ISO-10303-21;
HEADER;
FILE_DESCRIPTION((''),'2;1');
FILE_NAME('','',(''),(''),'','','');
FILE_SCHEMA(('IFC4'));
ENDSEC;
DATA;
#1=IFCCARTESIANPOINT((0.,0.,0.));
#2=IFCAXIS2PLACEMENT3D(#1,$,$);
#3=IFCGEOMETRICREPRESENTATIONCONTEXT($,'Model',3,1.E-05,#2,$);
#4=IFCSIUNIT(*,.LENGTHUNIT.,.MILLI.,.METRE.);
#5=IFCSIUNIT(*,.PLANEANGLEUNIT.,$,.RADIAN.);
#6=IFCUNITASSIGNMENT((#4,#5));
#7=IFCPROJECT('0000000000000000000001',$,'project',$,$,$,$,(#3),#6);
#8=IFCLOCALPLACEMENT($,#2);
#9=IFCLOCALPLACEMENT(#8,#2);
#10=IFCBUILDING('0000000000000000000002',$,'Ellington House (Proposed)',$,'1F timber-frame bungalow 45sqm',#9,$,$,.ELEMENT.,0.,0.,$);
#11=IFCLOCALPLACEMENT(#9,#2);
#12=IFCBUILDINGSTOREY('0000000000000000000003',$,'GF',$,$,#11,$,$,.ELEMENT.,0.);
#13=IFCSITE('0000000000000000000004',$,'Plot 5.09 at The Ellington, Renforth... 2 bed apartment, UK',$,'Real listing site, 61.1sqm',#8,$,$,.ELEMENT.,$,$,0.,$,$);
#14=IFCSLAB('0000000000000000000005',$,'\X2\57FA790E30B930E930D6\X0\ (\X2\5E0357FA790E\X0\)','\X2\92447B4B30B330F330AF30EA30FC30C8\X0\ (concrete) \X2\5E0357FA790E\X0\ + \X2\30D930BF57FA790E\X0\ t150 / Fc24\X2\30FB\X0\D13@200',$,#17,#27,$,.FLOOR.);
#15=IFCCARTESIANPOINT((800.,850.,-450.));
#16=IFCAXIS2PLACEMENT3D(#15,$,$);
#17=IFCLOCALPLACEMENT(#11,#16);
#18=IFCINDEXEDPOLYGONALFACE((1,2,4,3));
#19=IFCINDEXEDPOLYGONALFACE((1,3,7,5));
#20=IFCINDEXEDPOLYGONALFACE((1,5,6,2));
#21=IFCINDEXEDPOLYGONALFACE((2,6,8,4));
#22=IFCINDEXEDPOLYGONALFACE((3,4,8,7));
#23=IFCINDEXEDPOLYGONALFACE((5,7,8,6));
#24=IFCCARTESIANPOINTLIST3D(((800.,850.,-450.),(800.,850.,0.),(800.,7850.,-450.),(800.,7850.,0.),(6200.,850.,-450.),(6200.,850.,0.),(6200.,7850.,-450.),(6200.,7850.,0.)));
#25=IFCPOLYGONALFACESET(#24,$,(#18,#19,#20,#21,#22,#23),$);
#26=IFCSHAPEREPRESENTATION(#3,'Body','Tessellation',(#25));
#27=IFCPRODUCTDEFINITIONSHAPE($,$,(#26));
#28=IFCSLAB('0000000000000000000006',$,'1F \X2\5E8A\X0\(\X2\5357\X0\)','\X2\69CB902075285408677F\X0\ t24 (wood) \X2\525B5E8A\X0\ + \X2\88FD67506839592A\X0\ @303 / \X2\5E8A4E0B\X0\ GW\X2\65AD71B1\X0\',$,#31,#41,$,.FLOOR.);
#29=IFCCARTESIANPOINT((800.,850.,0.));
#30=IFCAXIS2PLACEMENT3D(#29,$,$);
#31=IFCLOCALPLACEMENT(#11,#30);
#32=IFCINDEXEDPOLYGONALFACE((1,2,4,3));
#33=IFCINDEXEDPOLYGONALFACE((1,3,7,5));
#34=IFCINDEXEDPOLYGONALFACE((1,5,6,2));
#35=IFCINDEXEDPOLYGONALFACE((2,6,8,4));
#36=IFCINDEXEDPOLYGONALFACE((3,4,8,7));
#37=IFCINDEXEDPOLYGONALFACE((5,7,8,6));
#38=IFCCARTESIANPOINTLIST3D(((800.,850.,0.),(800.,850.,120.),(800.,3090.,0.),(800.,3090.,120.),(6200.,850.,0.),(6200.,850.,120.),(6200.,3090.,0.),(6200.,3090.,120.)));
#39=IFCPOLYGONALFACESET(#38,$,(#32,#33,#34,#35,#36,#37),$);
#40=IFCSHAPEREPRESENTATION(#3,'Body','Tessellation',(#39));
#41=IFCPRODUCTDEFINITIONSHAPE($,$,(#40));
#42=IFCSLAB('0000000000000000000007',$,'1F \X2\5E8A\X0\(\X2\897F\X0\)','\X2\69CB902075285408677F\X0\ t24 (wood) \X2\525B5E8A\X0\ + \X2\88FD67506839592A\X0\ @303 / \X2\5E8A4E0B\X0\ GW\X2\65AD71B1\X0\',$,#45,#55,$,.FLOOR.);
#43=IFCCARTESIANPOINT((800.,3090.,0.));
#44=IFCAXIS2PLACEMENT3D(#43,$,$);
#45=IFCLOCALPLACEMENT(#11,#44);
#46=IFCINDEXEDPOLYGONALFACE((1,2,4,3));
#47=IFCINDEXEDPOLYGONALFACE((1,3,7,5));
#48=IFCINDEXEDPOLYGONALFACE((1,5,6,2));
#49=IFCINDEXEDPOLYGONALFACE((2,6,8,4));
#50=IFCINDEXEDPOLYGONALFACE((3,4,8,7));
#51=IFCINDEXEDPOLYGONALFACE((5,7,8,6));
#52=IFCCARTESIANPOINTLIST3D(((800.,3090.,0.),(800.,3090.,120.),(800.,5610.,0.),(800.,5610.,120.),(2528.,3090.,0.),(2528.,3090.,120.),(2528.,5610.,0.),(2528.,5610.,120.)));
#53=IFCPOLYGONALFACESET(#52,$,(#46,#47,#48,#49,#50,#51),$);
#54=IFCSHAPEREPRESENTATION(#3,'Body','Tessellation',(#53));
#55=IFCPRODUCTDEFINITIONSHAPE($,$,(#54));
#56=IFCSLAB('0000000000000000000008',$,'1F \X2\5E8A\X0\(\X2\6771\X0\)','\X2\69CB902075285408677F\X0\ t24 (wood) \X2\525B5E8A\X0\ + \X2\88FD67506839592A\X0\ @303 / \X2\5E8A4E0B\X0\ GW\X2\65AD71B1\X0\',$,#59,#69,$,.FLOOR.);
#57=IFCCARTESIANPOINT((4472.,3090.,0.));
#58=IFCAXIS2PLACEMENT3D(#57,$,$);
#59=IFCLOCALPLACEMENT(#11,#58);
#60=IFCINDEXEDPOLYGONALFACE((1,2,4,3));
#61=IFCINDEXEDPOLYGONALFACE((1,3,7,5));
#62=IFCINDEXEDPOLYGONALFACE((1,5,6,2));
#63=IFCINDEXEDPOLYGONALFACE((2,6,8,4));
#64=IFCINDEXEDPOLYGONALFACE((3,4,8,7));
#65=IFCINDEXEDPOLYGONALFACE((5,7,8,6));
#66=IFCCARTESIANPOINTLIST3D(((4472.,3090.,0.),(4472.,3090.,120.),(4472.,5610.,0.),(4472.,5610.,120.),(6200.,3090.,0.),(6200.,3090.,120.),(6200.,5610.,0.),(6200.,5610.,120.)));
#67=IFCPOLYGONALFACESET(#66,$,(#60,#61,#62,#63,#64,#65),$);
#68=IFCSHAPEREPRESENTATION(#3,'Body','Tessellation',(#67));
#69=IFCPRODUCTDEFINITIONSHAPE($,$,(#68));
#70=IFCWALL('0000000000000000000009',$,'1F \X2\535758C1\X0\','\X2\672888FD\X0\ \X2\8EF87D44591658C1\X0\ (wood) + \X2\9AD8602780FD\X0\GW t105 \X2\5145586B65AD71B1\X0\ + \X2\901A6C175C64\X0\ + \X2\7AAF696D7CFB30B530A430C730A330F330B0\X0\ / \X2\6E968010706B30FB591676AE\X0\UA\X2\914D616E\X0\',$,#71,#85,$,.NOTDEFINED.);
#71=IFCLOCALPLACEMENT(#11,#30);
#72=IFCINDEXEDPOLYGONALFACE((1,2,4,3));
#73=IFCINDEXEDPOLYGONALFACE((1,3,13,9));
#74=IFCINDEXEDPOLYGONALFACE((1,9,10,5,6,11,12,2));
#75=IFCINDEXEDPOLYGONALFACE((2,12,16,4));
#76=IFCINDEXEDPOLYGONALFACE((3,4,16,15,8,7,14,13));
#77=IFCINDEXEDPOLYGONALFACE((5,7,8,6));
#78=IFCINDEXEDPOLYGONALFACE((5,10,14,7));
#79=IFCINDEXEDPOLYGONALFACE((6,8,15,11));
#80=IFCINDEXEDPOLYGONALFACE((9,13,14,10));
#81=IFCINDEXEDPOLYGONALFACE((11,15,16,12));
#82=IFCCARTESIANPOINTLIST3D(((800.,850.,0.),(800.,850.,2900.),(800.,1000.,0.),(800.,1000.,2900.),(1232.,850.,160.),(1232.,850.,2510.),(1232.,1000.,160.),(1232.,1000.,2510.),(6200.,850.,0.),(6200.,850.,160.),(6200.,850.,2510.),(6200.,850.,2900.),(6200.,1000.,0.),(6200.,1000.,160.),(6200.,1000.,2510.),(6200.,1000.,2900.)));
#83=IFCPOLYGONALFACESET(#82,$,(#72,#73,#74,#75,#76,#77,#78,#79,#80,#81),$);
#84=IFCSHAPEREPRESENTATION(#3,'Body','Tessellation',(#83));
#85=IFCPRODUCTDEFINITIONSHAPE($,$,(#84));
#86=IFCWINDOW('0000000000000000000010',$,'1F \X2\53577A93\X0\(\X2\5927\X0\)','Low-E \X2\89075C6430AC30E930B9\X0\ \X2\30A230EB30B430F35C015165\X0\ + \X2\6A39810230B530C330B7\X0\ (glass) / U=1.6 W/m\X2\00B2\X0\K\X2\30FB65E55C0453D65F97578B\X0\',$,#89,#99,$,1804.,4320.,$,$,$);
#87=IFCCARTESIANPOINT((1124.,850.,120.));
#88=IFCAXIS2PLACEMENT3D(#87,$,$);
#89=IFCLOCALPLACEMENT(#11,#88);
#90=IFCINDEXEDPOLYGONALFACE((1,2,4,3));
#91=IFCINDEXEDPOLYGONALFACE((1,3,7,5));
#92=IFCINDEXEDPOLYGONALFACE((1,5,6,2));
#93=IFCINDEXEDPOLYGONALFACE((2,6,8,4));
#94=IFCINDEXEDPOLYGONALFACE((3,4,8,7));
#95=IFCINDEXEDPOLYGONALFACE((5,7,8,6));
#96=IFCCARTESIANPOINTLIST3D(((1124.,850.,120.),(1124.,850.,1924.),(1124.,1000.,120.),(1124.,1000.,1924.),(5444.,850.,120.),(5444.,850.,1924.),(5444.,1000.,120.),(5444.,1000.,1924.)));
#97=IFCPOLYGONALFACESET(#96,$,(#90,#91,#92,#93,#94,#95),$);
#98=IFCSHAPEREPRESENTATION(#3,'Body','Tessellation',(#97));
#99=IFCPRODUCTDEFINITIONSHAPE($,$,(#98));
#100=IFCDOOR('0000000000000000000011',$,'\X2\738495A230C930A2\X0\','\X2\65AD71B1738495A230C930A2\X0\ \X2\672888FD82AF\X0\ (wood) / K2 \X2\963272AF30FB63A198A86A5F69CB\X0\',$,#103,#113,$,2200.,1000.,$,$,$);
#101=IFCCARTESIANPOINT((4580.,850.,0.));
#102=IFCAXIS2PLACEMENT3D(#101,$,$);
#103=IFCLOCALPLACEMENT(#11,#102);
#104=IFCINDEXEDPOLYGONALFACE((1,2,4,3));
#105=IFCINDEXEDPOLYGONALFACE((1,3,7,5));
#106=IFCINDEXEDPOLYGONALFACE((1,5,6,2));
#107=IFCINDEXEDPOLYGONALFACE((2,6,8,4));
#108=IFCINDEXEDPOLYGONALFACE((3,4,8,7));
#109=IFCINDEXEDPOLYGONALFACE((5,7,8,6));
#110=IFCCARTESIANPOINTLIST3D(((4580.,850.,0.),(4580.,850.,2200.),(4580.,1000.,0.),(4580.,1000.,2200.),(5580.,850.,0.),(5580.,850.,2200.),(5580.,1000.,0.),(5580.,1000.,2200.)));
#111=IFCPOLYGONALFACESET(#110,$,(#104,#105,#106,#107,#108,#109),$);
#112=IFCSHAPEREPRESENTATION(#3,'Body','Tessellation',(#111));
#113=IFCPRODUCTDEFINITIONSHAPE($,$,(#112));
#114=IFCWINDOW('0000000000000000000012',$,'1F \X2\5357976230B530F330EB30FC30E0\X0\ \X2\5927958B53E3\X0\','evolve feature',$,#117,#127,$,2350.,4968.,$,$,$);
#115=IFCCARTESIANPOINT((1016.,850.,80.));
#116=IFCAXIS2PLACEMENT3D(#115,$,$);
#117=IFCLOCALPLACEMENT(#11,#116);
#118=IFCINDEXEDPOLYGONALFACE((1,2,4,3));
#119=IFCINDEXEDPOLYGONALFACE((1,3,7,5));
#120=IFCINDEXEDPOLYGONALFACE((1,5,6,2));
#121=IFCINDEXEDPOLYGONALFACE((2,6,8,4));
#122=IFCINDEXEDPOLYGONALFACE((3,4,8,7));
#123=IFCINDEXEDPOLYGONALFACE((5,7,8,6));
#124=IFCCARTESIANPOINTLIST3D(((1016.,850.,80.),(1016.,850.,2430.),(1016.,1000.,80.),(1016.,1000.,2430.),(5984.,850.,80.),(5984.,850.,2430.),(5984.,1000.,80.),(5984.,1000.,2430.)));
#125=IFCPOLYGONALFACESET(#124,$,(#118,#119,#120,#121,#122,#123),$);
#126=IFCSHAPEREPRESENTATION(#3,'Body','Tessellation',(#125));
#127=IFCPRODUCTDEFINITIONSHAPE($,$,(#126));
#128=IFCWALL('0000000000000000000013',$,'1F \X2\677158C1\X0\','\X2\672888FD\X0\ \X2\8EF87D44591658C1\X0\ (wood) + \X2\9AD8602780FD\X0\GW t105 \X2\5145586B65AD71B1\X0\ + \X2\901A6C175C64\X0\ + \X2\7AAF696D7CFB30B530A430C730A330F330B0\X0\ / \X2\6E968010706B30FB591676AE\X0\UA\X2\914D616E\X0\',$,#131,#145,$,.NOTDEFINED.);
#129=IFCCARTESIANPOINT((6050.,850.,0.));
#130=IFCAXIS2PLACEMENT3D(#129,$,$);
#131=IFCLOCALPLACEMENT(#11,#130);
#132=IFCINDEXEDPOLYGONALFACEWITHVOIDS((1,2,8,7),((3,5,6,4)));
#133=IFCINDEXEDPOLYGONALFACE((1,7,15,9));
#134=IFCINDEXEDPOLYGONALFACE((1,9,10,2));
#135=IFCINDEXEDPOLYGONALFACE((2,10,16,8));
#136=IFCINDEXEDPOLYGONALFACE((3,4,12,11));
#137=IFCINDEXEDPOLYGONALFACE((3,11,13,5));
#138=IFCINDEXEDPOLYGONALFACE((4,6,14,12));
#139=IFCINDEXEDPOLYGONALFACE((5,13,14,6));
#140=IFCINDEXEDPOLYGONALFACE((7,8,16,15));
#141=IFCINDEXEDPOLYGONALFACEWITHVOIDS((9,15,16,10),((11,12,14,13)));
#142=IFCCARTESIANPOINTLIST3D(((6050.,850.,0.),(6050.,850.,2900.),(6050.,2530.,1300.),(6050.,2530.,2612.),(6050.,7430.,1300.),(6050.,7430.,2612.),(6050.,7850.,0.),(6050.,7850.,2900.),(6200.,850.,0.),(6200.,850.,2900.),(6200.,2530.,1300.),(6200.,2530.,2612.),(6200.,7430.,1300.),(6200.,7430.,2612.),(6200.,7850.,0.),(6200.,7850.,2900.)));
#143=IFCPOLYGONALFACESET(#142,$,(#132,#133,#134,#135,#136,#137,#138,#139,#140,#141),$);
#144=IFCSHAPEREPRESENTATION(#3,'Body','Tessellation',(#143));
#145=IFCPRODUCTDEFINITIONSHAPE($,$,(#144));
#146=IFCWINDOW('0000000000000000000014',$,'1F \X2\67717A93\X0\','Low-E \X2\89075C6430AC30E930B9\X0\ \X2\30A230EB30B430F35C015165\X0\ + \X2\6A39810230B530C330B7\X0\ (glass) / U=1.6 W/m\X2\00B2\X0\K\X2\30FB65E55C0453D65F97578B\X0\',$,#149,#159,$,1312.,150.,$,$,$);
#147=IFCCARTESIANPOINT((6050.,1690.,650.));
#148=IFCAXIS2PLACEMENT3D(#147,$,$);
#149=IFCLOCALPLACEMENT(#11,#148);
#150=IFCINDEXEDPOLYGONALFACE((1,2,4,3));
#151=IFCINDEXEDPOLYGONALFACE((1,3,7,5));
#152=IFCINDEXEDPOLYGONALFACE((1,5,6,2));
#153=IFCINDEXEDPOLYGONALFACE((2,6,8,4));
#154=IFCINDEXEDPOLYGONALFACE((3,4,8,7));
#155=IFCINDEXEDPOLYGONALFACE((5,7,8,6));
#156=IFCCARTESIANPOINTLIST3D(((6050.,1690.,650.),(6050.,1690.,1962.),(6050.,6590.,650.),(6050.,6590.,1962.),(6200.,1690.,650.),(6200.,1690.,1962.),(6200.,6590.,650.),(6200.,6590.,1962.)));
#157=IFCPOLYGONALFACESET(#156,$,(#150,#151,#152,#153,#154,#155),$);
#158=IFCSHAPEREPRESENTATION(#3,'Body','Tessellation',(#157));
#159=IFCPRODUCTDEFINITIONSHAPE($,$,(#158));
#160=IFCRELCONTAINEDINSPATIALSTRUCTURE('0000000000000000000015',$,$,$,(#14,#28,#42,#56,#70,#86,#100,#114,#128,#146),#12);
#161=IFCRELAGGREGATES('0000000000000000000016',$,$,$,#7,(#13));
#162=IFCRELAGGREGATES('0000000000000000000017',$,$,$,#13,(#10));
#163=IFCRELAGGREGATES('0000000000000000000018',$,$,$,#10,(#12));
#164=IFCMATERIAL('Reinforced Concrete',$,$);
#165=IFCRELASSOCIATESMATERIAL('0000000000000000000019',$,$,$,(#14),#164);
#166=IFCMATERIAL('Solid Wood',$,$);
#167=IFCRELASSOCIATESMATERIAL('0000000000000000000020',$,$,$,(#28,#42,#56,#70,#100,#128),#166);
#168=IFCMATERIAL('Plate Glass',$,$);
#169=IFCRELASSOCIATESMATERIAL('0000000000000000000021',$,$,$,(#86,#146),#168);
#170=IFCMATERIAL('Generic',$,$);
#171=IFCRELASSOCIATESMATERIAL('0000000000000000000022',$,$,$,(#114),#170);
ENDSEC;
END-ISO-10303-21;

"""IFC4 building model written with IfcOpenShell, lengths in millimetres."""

from ifc_helpers import new_model, si_unit, frame, frame_2d, origin, place, context, project, spatial, rectangle, extrude, material, element, fill, save


model = new_model("IFC4")

# Units and contexts
model_context = context("Model", 3, precision=1e-05, world=origin())
ifc_project = project(units=[si_unit("LENGTHUNIT", "METRE", prefix="MILLI"), si_unit("PLANEANGLEUNIT", "RADIAN")], contexts=[model_context])

# Site, building, storey
site_placement = place(None, origin())
site = spatial("IfcSite", under=ifc_project, at=site_placement, Name="Plot 5.09 at The Ellington, Renforth... 2 bed apartment, UK", ObjectType="Real listing site, 61.1sqm", CompositionType="ELEMENT", RefElevation=0.0)
building_placement = place(site_placement, origin())
building = spatial("IfcBuilding", under=site, at=building_placement, Name="Ellington House (Proposed)", ObjectType="1F timber-frame bungalow 45sqm", CompositionType="ELEMENT", ElevationOfRefHeight=0.0, ElevationOfTerrain=0.0)
storey_placement = place(building_placement, origin())
storey = spatial("IfcBuildingStorey", under=building, at=storey_placement, Name="GF", CompositionType="ELEMENT", Elevation=0.0)

# Slabs
ifc_material_1 = material(Name="Reinforced Concrete")
slab_1_placement = place(storey_placement, frame((800.0, 850.0, -450.0)))
element("IfcSlab", 1, at=slab_1_placement, inside=storey, material=ifc_material_1, Name="基礎スラブ (布基礎)", Description="鉄筋コンクリート (concrete) 布基礎 + ベタ基礎 t150 / Fc24・D13@200", PredefinedType="FLOOR", context=model_context, shape_type="SweptSolid", body=[
    extrude(rectangle(XDim=5400.0, YDim=7000.0, at=frame_2d((2700.0, 3500.0))), frame((800.0, 850.0, -450.0)), (0.0, 0.0, 1.0), 450.0),
])
ifc_material_2 = material(Name="Solid Wood")
slab_2_placement = place(storey_placement, frame((800.0, 850.0, 0.0)))
element("IfcSlab", 2, at=slab_2_placement, inside=storey, material=ifc_material_2, Name="1F 床(南)", Description="構造用合板 t24 (wood) 剛床 + 製材根太 @303 / 床下 GW断熱", PredefinedType="FLOOR", context=model_context, shape_type="SweptSolid", body=[
    extrude(rectangle(XDim=5400.0, YDim=2240.0, at=frame_2d((2700.0, 1120.0))), frame((800.0, 850.0, 0.0)), (0.0, 0.0, 1.0), 120.0),
])
slab_3_placement = place(storey_placement, frame((800.0, 3090.0, 0.0)))
element("IfcSlab", 3, at=slab_3_placement, inside=storey, material=ifc_material_2, Name="1F 床(西)", Description="構造用合板 t24 (wood) 剛床 + 製材根太 @303 / 床下 GW断熱", PredefinedType="FLOOR", context=model_context, shape_type="SweptSolid", body=[
    extrude(rectangle(XDim=1728.0, YDim=2520.0, at=frame_2d((864.0, 1260.0))), frame((800.0, 3090.0, 0.0)), (0.0, 0.0, 1.0), 120.0),
])
slab_4_placement = place(storey_placement, frame((4472.0, 3090.0, 0.0)))
element("IfcSlab", 4, at=slab_4_placement, inside=storey, material=ifc_material_2, Name="1F 床(東)", Description="構造用合板 t24 (wood) 剛床 + 製材根太 @303 / 床下 GW断熱", PredefinedType="FLOOR", context=model_context, shape_type="SweptSolid", body=[
    extrude(rectangle(XDim=1728.0, YDim=2520.0, at=frame_2d((864.0, 1260.0))), frame((4472.0, 3090.0, 0.0)), (0.0, 0.0, 1.0), 120.0),
])

# Wall, openings, windows, door
wall_1_placement = place(storey_placement, frame((800.0, 850.0, 0.0)))
wall_1 = element("IfcWall", 5, at=wall_1_placement, inside=storey, material=ifc_material_2, Name="1F 南壁", Description="木製 軸組外壁 (wood) + 高性能GW t105 充填断熱 + 通気層 + 窯業系サイディング / 準耐火・外皮UA配慮", PredefinedType="NOTDEFINED", context=model_context, shape_type="SweptSolid", body=[
    extrude(rectangle(XDim=5400.0, YDim=150.0, at=frame_2d((2700.0, 75.0))), frame((800.0, 850.0, 0.0)), (0.0, 0.0, 1.0), 2900.0),
])
opening_1_placement = place(storey_placement, frame((1124.0, 850.0, 120.0)))
opening_1 = element("IfcOpeningElement", 6, at=opening_1_placement, cuts=wall_1, PredefinedType="NOTDEFINED", context=model_context, shape_type="SweptSolid", body=[
    extrude(rectangle(XDim=4320.0, YDim=150.0, at=frame_2d((2160.0, 75.0))), frame((1124.0, 850.0, 120.0)), (0.0, 0.0, 1.0), 1804.0),
])
opening_2_placement = place(storey_placement, frame((4580.0, 850.0, 0.0)))
opening_2 = element("IfcOpeningElement", 7, at=opening_2_placement, cuts=wall_1, PredefinedType="NOTDEFINED", context=model_context, shape_type="SweptSolid", body=[
    extrude(rectangle(XDim=1000.0, YDim=150.0, at=frame_2d((500.0, 75.0))), frame((4580.0, 850.0, 0.0)), (0.0, 0.0, 1.0), 2200.0),
])
opening_3_placement = place(storey_placement, frame((1016.0, 850.0, 80.0)))
opening_3 = element("IfcOpeningElement", 8, at=opening_3_placement, cuts=wall_1, PredefinedType="NOTDEFINED", context=model_context, shape_type="SweptSolid", body=[
    extrude(rectangle(XDim=4968.0, YDim=150.0, at=frame_2d((2484.0, 75.0))), frame((1016.0, 850.0, 80.0)), (0.0, 0.0, 1.0), 2350.0),
])
ifc_material_3 = material(Name="Plate Glass")
window_1_placement = place(storey_placement, frame((1124.0, 850.0, 120.0)))
window_1 = element("IfcWindow", 9, at=window_1_placement, inside=storey, material=ifc_material_3, Name="1F 南窓(大)", Description="Low-E 複層ガラス アルゴン封入 + 樹脂サッシ (glass) / U=1.6 W/m²K・日射取得型", OverallHeight=1804.0, OverallWidth=4320.0, context=model_context, shape_type="SweptSolid", body=[
    extrude(rectangle(XDim=4320.0, YDim=150.0, at=frame_2d((2160.0, 75.0))), frame((1124.0, 850.0, 120.0)), (0.0, 0.0, 1.0), 1804.0),
])
fill(opening_1, window_1)
door_placement = place(storey_placement, frame((4580.0, 850.0, 0.0)))
door = element("IfcDoor", 10, at=door_placement, inside=storey, material=ifc_material_2, Name="玄関ドア", Description="断熱玄関ドア 木製芯 (wood) / K2 防犯・採風機構", OverallHeight=2200.0, OverallWidth=1000.0, context=model_context, shape_type="SweptSolid", body=[
    extrude(rectangle(XDim=1000.0, YDim=150.0, at=frame_2d((500.0, 75.0))), frame((4580.0, 850.0, 0.0)), (0.0, 0.0, 1.0), 2200.0),
])
fill(opening_2, door)
ifc_material_4 = material(Name="Generic")
window_2_placement = place(storey_placement, frame((1016.0, 850.0, 80.0)))
window_2 = element("IfcWindow", 11, at=window_2_placement, inside=storey, material=ifc_material_4, Name="1F 南面サンルーム 大開口", Description="evolve feature", OverallHeight=2350.0, OverallWidth=4968.0, context=model_context, shape_type="SweptSolid", body=[
    extrude(rectangle(XDim=4968.0, YDim=150.0, at=frame_2d((2484.0, 75.0))), frame((1016.0, 850.0, 80.0)), (0.0, 0.0, 1.0), 2350.0),
])
fill(opening_3, window_2)

# Wall, opening, window
wall_2_placement = place(storey_placement, frame((6050.0, 850.0, 0.0)))
wall_2 = element("IfcWall", 12, at=wall_2_placement, inside=storey, material=ifc_material_2, Name="1F 東壁", Description="木製 軸組外壁 (wood) + 高性能GW t105 充填断熱 + 通気層 + 窯業系サイディング / 準耐火・外皮UA配慮", PredefinedType="NOTDEFINED", context=model_context, shape_type="SweptSolid", body=[
    extrude(rectangle(XDim=150.0, YDim=7000.0, at=frame_2d((75.0, 3500.0))), frame((6050.0, 850.0, 0.0)), (0.0, 0.0, 1.0), 2900.0),
])
opening_4_placement = place(storey_placement, frame((6050.0, 1690.0, 650.0)))
opening_4 = element("IfcOpeningElement", 13, at=opening_4_placement, cuts=wall_2, PredefinedType="NOTDEFINED", context=model_context, shape_type="SweptSolid", body=[
    extrude(rectangle(XDim=150.0, YDim=4900.0, at=frame_2d((75.0, 2450.0))), frame((6050.0, 1690.0, 650.0)), (0.0, 0.0, 1.0), 1312.0),
])
window_3_placement = place(storey_placement, frame((6050.0, 1690.0, 650.0)))
window_3 = element("IfcWindow", 14, at=window_3_placement, inside=storey, material=ifc_material_3, Name="1F 東窓", Description="Low-E 複層ガラス アルゴン封入 + 樹脂サッシ (glass) / U=1.6 W/m²K・日射取得型", OverallHeight=1312.0, OverallWidth=150.0, context=model_context, shape_type="SweptSolid", body=[
    extrude(rectangle(XDim=150.0, YDim=4900.0, at=frame_2d((75.0, 2450.0))), frame((6050.0, 1690.0, 650.0)), (0.0, 0.0, 1.0), 1312.0),
])
fill(opening_4, window_3)

save(model, "model.ifc")
